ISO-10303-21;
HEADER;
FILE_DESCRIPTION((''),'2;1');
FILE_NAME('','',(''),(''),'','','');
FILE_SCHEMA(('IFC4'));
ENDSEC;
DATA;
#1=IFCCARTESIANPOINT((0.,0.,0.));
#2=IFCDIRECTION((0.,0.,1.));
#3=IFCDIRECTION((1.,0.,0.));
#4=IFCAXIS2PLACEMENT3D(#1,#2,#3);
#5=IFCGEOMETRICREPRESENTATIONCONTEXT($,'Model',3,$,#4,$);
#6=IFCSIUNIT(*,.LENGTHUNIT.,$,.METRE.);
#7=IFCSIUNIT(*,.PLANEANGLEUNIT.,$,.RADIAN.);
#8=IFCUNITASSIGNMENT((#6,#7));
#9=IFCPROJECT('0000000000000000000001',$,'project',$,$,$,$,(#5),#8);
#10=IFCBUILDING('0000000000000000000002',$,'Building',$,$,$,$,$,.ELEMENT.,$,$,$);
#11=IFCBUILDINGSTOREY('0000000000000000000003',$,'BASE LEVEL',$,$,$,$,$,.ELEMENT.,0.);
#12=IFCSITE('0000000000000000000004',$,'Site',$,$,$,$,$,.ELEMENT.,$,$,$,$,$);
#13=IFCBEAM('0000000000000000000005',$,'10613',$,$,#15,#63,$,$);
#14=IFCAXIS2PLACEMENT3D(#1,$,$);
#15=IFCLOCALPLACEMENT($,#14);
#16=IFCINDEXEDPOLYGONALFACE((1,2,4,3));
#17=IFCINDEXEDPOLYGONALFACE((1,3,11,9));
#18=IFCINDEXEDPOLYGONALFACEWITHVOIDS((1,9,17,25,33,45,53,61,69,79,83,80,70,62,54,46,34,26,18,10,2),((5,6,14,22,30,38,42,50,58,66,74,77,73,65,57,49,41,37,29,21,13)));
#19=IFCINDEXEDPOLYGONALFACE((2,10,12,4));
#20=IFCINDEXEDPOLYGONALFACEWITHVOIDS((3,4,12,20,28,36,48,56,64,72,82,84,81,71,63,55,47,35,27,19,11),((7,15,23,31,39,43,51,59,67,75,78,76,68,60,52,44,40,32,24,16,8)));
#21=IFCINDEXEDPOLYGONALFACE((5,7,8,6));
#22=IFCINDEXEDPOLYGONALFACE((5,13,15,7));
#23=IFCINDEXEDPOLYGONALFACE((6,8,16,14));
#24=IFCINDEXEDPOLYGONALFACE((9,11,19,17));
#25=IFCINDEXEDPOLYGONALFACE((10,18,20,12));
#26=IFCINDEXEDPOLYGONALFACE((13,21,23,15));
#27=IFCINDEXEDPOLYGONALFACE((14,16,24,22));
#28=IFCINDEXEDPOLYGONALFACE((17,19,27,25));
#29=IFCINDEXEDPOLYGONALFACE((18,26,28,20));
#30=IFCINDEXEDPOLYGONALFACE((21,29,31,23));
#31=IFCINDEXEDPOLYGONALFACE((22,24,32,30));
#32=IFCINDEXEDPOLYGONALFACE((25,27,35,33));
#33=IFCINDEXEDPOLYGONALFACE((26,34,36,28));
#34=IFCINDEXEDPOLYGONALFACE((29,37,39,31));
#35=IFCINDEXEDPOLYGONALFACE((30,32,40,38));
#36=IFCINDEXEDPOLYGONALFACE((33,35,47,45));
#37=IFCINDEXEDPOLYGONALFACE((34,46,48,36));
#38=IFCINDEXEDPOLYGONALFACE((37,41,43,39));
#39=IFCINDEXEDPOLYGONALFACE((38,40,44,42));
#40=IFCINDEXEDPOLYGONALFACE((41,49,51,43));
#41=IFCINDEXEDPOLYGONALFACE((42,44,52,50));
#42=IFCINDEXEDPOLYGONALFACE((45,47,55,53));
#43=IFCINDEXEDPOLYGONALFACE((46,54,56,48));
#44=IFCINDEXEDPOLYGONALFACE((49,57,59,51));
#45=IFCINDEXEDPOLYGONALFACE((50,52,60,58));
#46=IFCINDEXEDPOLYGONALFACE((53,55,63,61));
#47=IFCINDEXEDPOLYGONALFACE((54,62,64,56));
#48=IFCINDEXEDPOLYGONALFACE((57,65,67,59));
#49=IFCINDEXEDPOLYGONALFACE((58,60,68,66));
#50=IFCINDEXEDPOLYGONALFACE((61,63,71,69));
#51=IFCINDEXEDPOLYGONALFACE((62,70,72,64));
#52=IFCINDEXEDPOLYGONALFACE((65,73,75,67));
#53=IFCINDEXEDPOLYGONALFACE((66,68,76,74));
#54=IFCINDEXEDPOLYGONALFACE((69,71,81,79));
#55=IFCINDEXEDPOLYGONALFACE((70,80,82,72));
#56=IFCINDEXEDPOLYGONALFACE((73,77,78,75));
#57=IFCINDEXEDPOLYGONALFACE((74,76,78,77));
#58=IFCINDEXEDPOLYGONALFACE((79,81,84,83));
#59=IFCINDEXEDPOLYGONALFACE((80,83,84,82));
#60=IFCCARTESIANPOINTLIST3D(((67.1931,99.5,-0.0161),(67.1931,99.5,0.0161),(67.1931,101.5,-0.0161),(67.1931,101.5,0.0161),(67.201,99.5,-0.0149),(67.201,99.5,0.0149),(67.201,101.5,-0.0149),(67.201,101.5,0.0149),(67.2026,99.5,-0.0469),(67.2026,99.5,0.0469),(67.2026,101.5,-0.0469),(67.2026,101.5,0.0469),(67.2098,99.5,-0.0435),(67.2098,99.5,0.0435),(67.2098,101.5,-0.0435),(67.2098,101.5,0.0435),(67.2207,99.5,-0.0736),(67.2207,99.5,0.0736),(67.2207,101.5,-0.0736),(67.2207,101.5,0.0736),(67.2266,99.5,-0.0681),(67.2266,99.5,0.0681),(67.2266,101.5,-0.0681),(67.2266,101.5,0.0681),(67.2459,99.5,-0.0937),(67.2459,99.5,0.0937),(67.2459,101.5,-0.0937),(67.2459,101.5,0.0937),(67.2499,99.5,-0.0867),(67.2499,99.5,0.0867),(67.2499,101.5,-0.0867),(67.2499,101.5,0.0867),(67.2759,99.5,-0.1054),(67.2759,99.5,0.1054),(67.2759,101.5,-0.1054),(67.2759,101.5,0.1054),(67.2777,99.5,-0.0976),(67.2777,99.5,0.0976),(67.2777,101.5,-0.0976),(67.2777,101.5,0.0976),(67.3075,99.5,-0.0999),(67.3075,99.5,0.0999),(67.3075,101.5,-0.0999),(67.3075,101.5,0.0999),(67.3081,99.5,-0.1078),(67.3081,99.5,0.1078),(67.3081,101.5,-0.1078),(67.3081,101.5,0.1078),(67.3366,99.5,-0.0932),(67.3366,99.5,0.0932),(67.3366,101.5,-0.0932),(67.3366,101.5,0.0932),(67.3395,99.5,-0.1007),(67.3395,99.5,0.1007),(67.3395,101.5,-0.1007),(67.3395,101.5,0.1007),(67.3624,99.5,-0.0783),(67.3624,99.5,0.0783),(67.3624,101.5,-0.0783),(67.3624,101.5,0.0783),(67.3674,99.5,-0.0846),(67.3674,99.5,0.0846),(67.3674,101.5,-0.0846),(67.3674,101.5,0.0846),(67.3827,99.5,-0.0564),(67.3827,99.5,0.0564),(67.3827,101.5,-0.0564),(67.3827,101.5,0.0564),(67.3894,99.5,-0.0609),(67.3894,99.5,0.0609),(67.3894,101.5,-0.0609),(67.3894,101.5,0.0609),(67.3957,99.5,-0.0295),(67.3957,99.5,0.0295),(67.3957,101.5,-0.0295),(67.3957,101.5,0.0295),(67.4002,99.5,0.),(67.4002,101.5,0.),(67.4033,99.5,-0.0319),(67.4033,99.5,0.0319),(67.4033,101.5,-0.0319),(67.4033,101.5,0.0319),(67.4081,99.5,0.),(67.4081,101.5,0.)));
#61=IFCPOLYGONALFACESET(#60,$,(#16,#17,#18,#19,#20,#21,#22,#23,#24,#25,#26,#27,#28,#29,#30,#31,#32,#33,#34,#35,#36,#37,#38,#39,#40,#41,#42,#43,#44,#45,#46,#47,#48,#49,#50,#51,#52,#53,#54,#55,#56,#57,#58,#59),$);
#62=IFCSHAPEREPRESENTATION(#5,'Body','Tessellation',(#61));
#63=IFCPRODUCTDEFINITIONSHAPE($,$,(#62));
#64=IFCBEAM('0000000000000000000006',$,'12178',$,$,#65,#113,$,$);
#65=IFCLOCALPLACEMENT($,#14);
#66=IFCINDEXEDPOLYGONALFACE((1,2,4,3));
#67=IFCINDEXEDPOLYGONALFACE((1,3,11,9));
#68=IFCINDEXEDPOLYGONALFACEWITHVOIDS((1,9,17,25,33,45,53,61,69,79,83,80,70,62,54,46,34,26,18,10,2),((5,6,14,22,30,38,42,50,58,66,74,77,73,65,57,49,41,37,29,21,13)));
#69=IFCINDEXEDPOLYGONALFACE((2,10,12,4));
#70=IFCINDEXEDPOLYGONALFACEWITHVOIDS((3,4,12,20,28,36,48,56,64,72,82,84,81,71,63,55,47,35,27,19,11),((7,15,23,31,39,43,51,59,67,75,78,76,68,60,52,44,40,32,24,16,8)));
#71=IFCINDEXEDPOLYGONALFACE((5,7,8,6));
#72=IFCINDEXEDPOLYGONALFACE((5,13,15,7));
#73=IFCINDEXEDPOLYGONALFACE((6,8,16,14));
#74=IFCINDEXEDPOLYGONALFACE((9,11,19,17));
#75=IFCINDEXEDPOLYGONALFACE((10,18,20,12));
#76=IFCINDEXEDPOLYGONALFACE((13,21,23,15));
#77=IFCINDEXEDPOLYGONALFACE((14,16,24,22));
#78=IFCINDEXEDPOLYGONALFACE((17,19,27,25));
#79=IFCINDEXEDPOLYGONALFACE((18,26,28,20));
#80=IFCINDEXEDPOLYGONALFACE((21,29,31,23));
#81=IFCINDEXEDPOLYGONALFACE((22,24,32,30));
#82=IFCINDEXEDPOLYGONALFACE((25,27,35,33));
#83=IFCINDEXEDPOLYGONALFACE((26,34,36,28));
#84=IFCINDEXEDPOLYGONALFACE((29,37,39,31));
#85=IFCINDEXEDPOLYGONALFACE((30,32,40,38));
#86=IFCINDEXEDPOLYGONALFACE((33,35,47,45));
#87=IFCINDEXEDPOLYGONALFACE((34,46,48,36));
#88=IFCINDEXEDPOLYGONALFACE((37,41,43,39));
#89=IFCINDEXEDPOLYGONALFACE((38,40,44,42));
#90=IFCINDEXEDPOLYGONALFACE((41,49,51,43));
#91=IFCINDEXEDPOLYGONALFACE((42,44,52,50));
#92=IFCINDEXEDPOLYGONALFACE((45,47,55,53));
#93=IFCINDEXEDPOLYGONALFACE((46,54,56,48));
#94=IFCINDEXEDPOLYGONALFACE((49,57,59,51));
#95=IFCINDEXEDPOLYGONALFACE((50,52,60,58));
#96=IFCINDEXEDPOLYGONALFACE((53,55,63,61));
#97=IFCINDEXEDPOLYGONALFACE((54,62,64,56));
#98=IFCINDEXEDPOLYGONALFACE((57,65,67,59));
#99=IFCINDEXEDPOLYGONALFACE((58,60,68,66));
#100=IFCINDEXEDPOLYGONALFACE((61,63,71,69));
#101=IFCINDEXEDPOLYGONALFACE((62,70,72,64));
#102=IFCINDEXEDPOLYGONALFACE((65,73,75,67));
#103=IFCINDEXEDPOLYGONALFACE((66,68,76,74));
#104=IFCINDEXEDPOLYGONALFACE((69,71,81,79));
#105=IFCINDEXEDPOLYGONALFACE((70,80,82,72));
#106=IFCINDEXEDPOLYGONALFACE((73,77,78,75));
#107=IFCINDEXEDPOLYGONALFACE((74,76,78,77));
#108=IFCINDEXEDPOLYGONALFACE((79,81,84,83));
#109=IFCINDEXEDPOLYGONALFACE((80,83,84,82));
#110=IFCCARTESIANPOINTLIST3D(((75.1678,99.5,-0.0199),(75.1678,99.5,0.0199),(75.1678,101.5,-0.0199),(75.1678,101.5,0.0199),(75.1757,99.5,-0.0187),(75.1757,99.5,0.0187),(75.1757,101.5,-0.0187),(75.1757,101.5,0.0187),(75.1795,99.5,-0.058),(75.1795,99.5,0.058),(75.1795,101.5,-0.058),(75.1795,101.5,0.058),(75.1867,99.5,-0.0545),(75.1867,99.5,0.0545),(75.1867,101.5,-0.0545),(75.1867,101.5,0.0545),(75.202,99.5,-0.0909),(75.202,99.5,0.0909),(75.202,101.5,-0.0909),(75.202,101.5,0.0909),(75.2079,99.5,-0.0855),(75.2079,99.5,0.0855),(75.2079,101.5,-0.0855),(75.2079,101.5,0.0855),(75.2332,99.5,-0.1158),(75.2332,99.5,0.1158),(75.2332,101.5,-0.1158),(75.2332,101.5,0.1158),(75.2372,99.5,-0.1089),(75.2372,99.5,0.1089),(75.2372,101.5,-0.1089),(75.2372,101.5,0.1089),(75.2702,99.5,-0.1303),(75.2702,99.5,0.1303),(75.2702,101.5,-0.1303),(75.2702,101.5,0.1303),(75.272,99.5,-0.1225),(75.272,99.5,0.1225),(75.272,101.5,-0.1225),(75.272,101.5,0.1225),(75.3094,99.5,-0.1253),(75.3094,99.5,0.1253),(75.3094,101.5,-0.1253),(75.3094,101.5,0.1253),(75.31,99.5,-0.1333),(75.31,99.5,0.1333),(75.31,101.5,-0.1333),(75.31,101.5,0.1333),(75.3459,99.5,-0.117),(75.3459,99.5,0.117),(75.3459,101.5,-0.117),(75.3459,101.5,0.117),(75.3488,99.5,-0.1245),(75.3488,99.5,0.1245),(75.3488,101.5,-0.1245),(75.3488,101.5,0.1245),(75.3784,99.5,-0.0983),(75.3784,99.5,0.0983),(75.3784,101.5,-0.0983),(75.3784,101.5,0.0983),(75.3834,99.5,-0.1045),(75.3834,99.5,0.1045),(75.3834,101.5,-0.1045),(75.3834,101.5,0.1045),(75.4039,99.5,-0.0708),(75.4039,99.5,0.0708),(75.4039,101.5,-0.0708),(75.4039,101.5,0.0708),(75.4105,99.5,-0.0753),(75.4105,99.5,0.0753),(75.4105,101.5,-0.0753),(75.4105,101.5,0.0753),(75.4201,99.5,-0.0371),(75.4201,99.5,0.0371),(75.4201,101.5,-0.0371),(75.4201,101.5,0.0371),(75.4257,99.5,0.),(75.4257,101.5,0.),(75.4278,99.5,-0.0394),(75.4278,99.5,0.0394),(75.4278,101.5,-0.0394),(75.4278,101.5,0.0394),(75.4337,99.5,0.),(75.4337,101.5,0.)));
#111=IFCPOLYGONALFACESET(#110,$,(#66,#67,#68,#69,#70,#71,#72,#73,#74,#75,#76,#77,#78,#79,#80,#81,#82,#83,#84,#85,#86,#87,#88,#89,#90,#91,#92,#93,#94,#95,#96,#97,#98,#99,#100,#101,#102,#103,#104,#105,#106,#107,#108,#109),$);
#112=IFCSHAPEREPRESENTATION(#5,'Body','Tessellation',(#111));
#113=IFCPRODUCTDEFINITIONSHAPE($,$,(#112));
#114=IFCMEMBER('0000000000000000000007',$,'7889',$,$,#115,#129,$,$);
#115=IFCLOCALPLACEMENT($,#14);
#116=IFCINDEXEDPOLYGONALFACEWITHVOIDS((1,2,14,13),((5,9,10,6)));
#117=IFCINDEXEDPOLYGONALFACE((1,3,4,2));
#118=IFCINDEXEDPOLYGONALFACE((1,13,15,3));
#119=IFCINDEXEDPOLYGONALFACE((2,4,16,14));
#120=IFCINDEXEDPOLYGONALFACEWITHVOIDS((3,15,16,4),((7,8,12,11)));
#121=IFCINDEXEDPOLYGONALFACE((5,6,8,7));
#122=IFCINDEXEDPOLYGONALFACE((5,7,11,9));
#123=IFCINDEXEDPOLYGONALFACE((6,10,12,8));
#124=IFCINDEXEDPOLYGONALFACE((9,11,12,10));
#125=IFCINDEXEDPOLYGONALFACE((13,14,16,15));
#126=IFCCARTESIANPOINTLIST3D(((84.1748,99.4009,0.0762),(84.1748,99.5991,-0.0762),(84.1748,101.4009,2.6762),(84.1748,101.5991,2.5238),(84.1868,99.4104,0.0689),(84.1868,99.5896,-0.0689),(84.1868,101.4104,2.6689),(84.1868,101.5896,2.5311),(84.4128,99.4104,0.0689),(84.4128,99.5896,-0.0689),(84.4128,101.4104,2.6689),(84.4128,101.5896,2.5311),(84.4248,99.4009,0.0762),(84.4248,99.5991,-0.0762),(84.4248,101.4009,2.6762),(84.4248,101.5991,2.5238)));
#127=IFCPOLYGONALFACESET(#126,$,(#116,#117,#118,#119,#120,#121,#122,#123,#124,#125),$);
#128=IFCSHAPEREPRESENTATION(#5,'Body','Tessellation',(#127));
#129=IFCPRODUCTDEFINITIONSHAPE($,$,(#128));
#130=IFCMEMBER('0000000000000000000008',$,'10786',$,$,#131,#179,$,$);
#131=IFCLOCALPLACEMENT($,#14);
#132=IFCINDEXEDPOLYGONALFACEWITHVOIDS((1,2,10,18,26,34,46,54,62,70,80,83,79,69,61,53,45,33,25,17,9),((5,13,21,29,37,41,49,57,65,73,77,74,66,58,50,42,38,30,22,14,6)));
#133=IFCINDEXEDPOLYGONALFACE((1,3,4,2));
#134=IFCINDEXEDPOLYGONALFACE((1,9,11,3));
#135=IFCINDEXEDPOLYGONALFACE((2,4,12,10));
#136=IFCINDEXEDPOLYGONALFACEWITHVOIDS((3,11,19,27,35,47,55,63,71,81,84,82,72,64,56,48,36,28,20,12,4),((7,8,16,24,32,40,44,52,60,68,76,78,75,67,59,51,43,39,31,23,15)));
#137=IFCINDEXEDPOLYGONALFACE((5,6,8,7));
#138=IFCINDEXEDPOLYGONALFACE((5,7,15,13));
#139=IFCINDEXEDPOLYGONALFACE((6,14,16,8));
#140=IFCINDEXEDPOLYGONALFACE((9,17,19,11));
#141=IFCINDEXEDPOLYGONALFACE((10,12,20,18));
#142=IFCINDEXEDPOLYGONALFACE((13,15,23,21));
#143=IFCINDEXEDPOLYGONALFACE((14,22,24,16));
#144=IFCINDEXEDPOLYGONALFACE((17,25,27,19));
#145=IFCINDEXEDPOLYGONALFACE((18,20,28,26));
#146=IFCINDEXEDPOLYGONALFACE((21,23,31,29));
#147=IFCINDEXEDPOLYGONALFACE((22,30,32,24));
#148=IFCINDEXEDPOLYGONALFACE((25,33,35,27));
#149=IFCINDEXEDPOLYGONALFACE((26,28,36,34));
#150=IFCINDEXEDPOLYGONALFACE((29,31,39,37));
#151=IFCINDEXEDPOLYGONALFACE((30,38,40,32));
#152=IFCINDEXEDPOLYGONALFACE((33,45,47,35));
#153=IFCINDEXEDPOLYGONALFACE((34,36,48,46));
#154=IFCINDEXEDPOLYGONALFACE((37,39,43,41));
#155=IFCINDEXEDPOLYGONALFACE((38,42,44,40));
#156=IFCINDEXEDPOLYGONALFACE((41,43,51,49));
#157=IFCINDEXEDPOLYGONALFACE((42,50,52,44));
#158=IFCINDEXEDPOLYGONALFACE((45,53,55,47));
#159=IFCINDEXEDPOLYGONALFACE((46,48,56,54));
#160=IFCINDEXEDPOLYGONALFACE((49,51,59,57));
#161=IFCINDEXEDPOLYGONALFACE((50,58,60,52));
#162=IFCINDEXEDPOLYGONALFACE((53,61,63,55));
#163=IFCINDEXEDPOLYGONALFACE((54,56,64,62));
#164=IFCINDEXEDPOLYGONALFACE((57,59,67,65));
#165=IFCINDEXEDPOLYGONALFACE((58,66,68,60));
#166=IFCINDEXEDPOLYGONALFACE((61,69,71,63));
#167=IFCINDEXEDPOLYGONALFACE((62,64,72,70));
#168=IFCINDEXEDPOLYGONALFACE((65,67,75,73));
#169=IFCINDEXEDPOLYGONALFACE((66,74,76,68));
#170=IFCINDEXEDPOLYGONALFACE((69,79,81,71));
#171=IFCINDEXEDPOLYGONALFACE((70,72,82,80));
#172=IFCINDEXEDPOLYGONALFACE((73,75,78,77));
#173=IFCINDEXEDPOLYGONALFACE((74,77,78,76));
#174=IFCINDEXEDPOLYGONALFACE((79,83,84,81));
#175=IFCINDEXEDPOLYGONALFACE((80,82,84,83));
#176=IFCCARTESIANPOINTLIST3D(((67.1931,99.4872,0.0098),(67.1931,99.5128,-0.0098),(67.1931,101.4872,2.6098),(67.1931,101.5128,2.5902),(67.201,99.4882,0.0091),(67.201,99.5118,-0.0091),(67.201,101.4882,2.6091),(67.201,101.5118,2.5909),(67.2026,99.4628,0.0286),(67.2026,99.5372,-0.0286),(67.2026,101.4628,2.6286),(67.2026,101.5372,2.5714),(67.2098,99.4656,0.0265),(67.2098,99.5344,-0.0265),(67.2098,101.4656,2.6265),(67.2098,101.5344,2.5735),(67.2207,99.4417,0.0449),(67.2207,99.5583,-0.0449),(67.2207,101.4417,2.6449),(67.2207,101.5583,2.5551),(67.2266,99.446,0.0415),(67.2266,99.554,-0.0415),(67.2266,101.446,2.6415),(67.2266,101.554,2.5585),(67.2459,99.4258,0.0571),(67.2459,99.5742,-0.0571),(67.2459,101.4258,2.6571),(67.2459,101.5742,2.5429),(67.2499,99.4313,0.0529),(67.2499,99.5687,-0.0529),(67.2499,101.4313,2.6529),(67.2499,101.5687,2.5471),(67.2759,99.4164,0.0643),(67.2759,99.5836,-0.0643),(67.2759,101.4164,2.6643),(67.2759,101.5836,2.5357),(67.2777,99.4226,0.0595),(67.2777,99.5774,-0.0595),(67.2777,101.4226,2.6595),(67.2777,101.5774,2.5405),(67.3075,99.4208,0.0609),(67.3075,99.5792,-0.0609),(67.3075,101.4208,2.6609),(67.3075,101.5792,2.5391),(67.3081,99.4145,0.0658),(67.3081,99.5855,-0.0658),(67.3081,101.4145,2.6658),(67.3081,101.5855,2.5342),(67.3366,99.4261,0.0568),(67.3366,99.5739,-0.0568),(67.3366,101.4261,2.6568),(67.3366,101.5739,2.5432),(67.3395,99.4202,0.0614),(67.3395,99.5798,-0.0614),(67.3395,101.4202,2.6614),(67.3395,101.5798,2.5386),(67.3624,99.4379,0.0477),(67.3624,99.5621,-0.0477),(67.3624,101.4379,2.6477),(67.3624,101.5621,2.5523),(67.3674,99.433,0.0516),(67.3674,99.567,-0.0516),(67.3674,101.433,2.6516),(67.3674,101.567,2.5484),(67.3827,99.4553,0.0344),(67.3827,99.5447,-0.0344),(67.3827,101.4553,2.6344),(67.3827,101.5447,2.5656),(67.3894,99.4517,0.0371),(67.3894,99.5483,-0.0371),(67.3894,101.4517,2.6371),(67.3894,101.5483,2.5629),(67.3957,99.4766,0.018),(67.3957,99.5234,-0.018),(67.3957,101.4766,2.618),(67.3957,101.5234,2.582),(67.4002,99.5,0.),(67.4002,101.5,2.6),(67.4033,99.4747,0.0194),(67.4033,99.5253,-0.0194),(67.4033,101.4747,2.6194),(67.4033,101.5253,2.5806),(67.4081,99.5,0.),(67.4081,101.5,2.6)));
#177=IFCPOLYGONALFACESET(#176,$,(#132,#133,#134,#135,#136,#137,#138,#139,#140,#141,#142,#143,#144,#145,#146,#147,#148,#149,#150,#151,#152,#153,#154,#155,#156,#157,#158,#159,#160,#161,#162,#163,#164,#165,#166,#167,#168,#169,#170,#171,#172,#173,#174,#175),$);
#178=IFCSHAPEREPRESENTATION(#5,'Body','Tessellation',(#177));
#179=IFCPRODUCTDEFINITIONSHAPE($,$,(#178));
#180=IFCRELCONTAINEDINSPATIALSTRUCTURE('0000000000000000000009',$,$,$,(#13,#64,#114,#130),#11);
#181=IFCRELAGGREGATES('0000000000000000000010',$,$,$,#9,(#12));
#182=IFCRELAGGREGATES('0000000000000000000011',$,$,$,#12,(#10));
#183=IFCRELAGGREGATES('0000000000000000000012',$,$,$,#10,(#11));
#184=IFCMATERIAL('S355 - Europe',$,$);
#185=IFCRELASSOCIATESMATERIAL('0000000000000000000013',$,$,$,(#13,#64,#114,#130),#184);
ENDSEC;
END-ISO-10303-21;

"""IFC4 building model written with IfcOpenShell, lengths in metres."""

from ifc_helpers import new_model, si_unit, frame, origin_with_axes, origin_2d_with_axis, place, context, project, spatial, hollow_rectangle, hollow_circle, extrude, material, material_profile, profile_set, profile_usage, element, save


model = new_model("IFC4")

# Units and contexts
model_context = context("Model", 3, world=origin_with_axes())
ifc_project = project(units=[si_unit("LENGTHUNIT", "METRE"), si_unit("PLANEANGLEUNIT", "RADIAN")], contexts=[model_context])

# Site, building, storey
site = spatial("IfcSite", under=ifc_project, Name="Site", CompositionType="ELEMENT")
building = spatial("IfcBuilding", under=site, Name="Building", CompositionType="ELEMENT")
storey = spatial("IfcBuildingStorey", under=building, Name="BASE LEVEL", CompositionType="ELEMENT", Elevation=0.0)

# Shared definitions
ifc_material = material(Name="S355 - Europe")

# Beams
ifc_material_profile_1 = material_profile(ifc_material, hollow_circle(Radius=0.1081, WallThickness=0.008, at=origin_2d_with_axis()))
ifc_profile_set_1 = profile_set([ifc_material_profile_1])
ifc_profile_usage_1 = profile_usage(ifc_profile_set_1, cardinal=10)
beam_1_placement = place(None, frame((67.3, 101.5, 0.0), z_axis=(0.0, -1.0, 0.0), x_axis=(1.0, 0.0, 0.0)))
element("IfcBeam", 1, at=beam_1_placement, inside=storey, material=ifc_profile_usage_1, Name="10613", context=model_context, shape_type="SweptSolid", body=[
    extrude(hollow_circle(Radius=0.1081, WallThickness=0.008, at=origin_2d_with_axis()), origin_with_axes(), (0.0, 0.0, 1.0), 2.0),
])
ifc_material_profile_2 = material_profile(ifc_material, hollow_circle(Radius=0.1337, WallThickness=0.008, at=origin_2d_with_axis()))
ifc_profile_set_2 = profile_set([ifc_material_profile_2])
ifc_profile_usage_2 = profile_usage(ifc_profile_set_2, cardinal=10)
beam_2_placement = place(None, frame((75.3, 101.5, 0.0), z_axis=(0.0, -1.0, 0.0), x_axis=(1.0, 0.0, 0.0)))
element("IfcBeam", 2, at=beam_2_placement, inside=storey, material=ifc_profile_usage_2, Name="12178", context=model_context, shape_type="SweptSolid", body=[
    extrude(hollow_circle(Radius=0.1337, WallThickness=0.008, at=origin_2d_with_axis()), origin_with_axes(), (0.0, 0.0, 1.0), 2.0),
])

# Members
ifc_material_profile_3 = material_profile(ifc_material, hollow_rectangle(XDim=0.25, YDim=0.25, WallThickness=0.012, at=origin_2d_with_axis()))
ifc_profile_set_3 = profile_set([ifc_material_profile_3])
ifc_profile_usage_3 = profile_usage(ifc_profile_set_3, cardinal=10)
member_1_placement = place(None, frame((84.2998, 101.5, 2.6), z_axis=(0.0, -0.609711, -0.792624), x_axis=(1.0, 0.0, 0.0)))
element("IfcMember", 3, at=member_1_placement, inside=storey, material=ifc_profile_usage_3, Name="7889", context=model_context, shape_type="SweptSolid", body=[
    extrude(hollow_rectangle(XDim=0.25, YDim=0.25, WallThickness=0.012, at=origin_2d_with_axis()), origin_with_axes(), (0.0, 0.0, 1.0), 3.2802),
])
ifc_material_profile_4 = material_profile(ifc_material, hollow_circle(Radius=0.1081, WallThickness=0.008, at=origin_2d_with_axis()))
ifc_profile_set_4 = profile_set([ifc_material_profile_4])
ifc_profile_usage_4 = profile_usage(ifc_profile_set_4, cardinal=10)
member_2_placement = place(None, frame((67.3, 101.5, 2.6), z_axis=(0.0, -0.609711, -0.792624), x_axis=(1.0, 0.0, 0.0)))
element("IfcMember", 4, at=member_2_placement, inside=storey, material=ifc_profile_usage_4, Name="10786", context=model_context, shape_type="SweptSolid", body=[
    extrude(hollow_circle(Radius=0.1081, WallThickness=0.008, at=origin_2d_with_axis()), origin_with_axes(), (0.0, 0.0, 1.0), 3.2802),
])

save(model, "model.ifc")
